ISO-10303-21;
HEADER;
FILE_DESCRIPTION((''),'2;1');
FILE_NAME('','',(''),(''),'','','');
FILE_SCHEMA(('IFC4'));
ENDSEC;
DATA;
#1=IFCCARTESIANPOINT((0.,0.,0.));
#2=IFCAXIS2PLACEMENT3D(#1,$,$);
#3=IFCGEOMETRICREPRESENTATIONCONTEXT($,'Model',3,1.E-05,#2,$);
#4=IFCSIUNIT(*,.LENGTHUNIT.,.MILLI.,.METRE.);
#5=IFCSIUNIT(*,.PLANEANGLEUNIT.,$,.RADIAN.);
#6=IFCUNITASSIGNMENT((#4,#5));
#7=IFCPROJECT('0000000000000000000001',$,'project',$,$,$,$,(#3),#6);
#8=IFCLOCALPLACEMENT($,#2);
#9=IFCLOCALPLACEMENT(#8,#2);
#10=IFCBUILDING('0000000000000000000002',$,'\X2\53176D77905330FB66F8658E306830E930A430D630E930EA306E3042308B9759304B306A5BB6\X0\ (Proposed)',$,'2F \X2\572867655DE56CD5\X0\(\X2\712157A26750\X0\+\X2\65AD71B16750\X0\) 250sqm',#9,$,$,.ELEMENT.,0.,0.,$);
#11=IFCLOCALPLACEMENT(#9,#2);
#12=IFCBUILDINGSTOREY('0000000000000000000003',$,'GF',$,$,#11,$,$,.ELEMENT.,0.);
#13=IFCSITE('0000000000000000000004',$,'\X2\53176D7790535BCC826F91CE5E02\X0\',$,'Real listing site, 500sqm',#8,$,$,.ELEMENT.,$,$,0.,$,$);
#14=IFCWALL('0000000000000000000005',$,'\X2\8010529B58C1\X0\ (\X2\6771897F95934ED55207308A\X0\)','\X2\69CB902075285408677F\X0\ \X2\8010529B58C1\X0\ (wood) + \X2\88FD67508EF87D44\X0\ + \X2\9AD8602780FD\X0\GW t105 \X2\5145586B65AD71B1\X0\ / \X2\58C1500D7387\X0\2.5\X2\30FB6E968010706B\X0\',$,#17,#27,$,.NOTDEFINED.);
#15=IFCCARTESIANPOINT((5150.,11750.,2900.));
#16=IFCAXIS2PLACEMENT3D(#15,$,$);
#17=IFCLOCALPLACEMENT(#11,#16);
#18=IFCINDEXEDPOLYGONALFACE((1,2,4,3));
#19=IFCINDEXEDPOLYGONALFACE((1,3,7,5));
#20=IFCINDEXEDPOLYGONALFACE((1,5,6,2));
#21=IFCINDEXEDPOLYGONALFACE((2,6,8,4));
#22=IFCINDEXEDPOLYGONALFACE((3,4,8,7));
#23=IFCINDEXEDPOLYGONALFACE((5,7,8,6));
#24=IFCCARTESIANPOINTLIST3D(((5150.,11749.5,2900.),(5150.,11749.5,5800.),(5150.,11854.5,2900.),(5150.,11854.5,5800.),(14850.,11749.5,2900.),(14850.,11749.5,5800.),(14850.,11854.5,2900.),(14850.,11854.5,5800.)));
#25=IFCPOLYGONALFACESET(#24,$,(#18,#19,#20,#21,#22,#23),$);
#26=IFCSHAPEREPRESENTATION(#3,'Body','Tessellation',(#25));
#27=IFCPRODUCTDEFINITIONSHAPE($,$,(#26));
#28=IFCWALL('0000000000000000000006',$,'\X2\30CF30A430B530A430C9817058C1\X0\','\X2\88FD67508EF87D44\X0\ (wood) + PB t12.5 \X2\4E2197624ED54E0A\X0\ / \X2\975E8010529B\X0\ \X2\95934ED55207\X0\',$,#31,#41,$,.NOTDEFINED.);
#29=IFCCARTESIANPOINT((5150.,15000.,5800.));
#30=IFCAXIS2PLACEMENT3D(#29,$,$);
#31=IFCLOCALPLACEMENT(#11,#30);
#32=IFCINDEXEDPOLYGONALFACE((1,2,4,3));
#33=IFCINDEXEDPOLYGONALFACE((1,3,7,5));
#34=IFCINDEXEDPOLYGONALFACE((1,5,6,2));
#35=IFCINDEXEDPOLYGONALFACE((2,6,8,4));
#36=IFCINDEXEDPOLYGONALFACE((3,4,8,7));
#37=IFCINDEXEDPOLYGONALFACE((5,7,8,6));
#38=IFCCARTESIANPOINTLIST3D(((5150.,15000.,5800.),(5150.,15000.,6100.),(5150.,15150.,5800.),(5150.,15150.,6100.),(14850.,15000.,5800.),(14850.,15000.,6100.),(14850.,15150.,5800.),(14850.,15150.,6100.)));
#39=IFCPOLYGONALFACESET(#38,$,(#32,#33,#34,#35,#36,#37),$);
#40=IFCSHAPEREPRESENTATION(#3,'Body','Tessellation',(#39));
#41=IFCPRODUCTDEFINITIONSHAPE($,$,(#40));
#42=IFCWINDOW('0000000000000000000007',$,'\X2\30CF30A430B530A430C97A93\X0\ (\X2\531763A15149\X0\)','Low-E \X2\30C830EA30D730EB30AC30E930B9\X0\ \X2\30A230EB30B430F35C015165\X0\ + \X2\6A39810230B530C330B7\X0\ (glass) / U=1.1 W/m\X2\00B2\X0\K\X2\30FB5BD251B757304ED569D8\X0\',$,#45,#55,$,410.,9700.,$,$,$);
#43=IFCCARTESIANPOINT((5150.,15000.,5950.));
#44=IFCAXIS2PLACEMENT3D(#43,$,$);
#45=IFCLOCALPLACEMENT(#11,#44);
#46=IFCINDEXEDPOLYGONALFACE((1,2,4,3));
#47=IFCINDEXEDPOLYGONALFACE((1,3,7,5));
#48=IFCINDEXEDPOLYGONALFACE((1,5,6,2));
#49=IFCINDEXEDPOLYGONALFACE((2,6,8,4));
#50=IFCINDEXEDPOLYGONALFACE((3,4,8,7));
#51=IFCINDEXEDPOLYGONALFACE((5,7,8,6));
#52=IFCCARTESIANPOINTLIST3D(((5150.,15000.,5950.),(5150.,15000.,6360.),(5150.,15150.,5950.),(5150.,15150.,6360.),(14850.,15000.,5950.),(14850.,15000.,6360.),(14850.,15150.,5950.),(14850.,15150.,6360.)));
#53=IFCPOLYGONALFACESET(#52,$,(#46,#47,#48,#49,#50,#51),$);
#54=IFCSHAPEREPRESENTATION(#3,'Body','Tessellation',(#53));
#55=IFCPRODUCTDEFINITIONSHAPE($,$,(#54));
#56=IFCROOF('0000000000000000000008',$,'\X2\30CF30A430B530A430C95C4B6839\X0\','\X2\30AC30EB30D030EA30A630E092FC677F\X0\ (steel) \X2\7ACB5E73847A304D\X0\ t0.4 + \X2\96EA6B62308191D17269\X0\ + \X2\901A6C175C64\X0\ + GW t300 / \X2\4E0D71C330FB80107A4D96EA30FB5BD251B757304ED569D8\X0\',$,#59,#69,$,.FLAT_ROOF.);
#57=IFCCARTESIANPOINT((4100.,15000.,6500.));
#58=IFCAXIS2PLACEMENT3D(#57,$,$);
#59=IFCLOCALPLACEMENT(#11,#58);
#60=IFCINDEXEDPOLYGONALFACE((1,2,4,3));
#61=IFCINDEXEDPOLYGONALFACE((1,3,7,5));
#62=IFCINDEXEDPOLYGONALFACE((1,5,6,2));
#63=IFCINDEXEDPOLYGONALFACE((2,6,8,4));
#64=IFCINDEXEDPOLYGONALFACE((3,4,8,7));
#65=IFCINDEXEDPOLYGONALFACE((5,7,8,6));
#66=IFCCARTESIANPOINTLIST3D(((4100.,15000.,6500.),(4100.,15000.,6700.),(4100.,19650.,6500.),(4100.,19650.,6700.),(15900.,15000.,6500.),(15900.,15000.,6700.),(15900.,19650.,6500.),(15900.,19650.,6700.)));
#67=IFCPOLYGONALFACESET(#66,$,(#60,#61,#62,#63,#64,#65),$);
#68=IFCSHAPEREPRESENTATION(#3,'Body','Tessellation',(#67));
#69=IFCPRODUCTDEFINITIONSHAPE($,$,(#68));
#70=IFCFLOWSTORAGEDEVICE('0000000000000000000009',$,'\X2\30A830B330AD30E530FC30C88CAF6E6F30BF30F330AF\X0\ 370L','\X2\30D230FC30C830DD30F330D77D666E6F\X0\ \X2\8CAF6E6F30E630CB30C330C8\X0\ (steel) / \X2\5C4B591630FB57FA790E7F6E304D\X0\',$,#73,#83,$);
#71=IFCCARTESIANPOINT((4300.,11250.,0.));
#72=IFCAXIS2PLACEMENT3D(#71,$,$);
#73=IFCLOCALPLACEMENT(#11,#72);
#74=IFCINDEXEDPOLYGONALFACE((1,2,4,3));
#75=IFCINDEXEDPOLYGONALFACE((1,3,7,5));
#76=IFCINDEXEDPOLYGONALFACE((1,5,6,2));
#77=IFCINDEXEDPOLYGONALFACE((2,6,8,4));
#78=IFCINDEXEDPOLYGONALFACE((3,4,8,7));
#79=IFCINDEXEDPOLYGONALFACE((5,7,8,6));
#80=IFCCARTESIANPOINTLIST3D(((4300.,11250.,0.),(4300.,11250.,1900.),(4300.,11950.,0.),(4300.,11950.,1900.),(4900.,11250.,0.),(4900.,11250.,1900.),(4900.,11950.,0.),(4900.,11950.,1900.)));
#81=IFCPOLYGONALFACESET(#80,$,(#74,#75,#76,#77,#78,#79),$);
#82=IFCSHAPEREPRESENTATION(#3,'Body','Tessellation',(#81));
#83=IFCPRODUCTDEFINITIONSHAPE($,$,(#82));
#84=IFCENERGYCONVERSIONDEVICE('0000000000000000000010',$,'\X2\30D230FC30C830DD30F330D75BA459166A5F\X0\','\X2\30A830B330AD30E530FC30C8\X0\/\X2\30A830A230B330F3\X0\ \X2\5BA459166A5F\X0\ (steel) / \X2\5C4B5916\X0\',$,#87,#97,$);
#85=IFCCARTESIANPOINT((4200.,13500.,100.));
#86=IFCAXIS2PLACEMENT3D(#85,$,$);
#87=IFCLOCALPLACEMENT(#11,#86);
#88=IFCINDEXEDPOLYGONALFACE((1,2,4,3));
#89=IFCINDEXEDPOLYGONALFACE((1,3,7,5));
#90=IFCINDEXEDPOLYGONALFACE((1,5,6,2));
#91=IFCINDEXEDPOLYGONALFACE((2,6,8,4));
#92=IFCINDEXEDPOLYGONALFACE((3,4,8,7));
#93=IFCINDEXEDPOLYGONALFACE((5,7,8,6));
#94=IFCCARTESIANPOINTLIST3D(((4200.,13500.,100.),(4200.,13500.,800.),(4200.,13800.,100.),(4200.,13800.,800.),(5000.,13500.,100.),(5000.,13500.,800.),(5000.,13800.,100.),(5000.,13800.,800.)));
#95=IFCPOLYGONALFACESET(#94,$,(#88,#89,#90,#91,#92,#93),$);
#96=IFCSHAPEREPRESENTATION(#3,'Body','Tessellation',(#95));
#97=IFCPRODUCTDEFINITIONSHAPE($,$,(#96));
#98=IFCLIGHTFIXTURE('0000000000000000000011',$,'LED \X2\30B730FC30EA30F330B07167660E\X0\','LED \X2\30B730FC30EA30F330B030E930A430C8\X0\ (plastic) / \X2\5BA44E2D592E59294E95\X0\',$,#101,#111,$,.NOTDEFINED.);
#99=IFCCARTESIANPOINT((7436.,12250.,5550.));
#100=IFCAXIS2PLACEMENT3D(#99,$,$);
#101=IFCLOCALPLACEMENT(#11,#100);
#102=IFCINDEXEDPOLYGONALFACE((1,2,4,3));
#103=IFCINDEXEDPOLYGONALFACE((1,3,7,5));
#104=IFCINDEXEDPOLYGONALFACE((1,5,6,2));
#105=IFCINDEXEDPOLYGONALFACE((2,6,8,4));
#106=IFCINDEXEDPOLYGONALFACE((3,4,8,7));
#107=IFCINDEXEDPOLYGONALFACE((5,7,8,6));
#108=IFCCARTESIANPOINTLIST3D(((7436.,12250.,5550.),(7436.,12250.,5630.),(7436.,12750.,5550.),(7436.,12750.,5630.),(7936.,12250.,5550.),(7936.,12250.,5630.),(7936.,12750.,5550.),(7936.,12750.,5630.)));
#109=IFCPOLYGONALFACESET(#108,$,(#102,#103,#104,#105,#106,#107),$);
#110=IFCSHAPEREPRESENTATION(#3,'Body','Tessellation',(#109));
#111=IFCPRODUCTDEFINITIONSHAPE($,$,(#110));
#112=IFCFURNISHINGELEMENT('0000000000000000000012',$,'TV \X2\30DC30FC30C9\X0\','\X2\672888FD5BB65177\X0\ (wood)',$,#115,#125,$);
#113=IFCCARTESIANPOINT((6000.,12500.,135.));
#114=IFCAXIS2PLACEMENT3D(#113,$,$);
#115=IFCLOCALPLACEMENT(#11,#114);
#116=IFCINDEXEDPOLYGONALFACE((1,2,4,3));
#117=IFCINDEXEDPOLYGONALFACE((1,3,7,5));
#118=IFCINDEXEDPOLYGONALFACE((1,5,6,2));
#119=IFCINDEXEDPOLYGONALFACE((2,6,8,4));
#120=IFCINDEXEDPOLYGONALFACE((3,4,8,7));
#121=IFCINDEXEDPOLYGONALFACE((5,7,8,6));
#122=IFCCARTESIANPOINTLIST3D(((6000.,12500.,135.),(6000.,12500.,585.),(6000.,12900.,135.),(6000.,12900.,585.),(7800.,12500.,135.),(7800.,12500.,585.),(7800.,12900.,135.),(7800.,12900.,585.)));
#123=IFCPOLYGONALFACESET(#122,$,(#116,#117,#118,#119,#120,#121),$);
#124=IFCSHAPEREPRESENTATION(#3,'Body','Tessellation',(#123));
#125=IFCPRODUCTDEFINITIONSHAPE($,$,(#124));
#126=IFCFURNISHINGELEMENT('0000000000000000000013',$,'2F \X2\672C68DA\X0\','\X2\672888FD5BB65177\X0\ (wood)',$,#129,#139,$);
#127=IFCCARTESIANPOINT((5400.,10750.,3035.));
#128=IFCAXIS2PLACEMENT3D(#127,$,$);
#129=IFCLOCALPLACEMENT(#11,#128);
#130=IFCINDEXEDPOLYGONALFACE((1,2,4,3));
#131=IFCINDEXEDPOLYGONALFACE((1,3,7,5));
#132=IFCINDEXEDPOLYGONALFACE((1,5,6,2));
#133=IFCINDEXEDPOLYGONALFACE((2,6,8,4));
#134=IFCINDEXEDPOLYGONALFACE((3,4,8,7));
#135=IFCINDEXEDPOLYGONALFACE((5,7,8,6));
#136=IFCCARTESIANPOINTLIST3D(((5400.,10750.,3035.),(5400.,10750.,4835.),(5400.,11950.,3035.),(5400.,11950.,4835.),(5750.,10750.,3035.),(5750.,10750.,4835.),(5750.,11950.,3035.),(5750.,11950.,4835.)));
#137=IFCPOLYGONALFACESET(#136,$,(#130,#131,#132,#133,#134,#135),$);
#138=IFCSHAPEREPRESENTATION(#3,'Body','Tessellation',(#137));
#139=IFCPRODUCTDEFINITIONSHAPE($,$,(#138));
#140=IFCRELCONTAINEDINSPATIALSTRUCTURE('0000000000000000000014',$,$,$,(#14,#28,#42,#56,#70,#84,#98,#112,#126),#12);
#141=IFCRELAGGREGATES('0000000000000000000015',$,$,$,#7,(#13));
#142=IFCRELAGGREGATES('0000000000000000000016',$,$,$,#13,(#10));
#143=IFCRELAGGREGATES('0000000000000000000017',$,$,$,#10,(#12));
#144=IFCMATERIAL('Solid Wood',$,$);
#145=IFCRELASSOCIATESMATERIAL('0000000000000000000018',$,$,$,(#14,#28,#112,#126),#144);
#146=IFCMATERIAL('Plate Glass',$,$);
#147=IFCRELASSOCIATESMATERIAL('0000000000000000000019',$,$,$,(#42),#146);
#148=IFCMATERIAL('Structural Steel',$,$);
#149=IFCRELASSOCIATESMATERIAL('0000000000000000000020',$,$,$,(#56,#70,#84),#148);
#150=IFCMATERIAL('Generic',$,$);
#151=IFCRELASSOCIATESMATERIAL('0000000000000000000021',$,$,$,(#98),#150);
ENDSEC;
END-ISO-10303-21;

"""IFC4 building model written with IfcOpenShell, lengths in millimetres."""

from ifc_helpers import new_model, si_unit, frame, frame_2d, origin, place, context, project, spatial, rectangle, extrude, material, element, fill, save


model = new_model("IFC4")

# Units and contexts
model_context = context("Model", 3, precision=1e-05, world=origin())
ifc_project = project(units=[si_unit("LENGTHUNIT", "METRE", prefix="MILLI"), si_unit("PLANEANGLEUNIT", "RADIAN")], contexts=[model_context])

# Site, building, storey
site_placement = place(None, origin())
site = spatial("IfcSite", under=ifc_project, at=site_placement, Name="北海道富良野市", ObjectType="Real listing site, 500sqm", CompositionType="ELEMENT", RefElevation=0.0)
building_placement = place(site_placement, origin())
building = spatial("IfcBuilding", under=site, at=building_placement, Name="北海道・書斎とライブラリのある静かな家 (Proposed)", ObjectType="2F 在来工法(無垢材+断熱材) 250sqm", CompositionType="ELEMENT", ElevationOfRefHeight=0.0, ElevationOfTerrain=0.0)
storey_placement = place(building_placement, origin())
storey = spatial("IfcBuildingStorey", under=building, at=storey_placement, Name="GF", CompositionType="ELEMENT", Elevation=0.0)

# Shared definitions
ifc_material_1 = material(Name="Solid Wood")

# Wall
wall_1_placement = place(storey_placement, frame((5150.0, 11750.0, 2900.0)))
element("IfcWall", 1, at=wall_1_placement, inside=storey, material=ifc_material_1, Name="耐力壁 (東西間仕切り)", Description="構造用合板 耐力壁 (wood) + 製材軸組 + 高性能GW t105 充填断熱 / 壁倍率2.5・準耐火", PredefinedType="NOTDEFINED", context=model_context, shape_type="SweptSolid", body=[
    extrude(rectangle(XDim=9700.0, YDim=105.0, at=frame_2d((4850.0, 52.0))), frame((5150.0, 11750.0, 2900.0)), (0.0, 0.0, 1.0), 2900.0),
])

# Wall, opening, window
wall_2_placement = place(storey_placement, frame((5150.0, 15000.0, 5800.0)))
wall_2 = element("IfcWall", 2, at=wall_2_placement, inside=storey, material=ifc_material_1, Name="ハイサイド腰壁", Description="製材軸組 (wood) + PB t12.5 両面仕上 / 非耐力 間仕切", PredefinedType="NOTDEFINED", context=model_context, shape_type="SweptSolid", body=[
    extrude(rectangle(XDim=9700.0, YDim=150.0, at=frame_2d((4850.0, 75.0))), frame((5150.0, 15000.0, 5800.0)), (0.0, 0.0, 1.0), 700.0),
])
opening_1_placement = place(storey_placement, frame((5150.0, 15000.0, 5950.0)))
opening_1 = element("IfcOpeningElement", 3, at=opening_1_placement, cuts=wall_2, PredefinedType="NOTDEFINED", context=model_context, shape_type="SweptSolid", body=[
    extrude(rectangle(XDim=9700.0, YDim=150.0, at=frame_2d((4850.0, 75.0))), frame((5150.0, 15000.0, 5950.0)), (0.0, 0.0, 1.0), 410.0),
])
ifc_material_2 = material(Name="Plate Glass")
window_placement = place(storey_placement, frame((5150.0, 15000.0, 5950.0)))
window = element("IfcWindow", 4, at=window_placement, inside=storey, material=ifc_material_2, Name="ハイサイド窓 (北採光)", Description="Low-E トリプルガラス アルゴン封入 + 樹脂サッシ (glass) / U=1.1 W/m²K・寒冷地仕様", OverallHeight=410.0, OverallWidth=9700.0, context=model_context, shape_type="SweptSolid", body=[
    extrude(rectangle(XDim=9700.0, YDim=150.0, at=frame_2d((4850.0, 75.0))), frame((5150.0, 15000.0, 5950.0)), (0.0, 0.0, 1.0), 410.0),
])
fill(opening_1, window)

# Roof
ifc_material_3 = material(Name="Structural Steel")
roof_placement = place(storey_placement, frame((4100.0, 15000.0, 6500.0)))
element("IfcRoof", 5, at=roof_placement, inside=storey, material=ifc_material_3, Name="ハイサイド屋根", Description="ガルバリウム鋼板 (steel) 立平葺き t0.4 + 雪止め金物 + 通気層 + GW t300 / 不燃・耐積雪・寒冷地仕様", PredefinedType="FLAT_ROOF", context=model_context, shape_type="SweptSolid", body=[
    extrude(rectangle(XDim=11800.0, YDim=4650.0, at=frame_2d((5900.0, 2325.0))), frame((4100.0, 15000.0, 6500.0)), (0.0, 0.0, 1.0), 200.0),
])

# Flow storage device
flow_storage_device_placement = place(storey_placement, frame((4300.0, 11250.0, 0.0)))
element("IfcFlowStorageDevice", 6, at=flow_storage_device_placement, inside=storey, material=ifc_material_3, Name="エコキュート貯湯タンク 370L", Description="ヒートポンプ給湯 貯湯ユニット (steel) / 屋外・基礎置き", context=model_context, shape_type="SweptSolid", body=[
    extrude(rectangle(XDim=600.0, YDim=700.0, at=frame_2d((300.0, 350.0))), frame((4300.0, 11250.0, 0.0)), (0.0, 0.0, 1.0), 1900.0),
])

# Energy conversion device
energy_conversion_device_placement = place(storey_placement, frame((4200.0, 13500.0, 100.0)))
element("IfcEnergyConversionDevice", 7, at=energy_conversion_device_placement, inside=storey, material=ifc_material_3, Name="ヒートポンプ室外機", Description="エコキュート/エアコン 室外機 (steel) / 屋外", context=model_context, shape_type="SweptSolid", body=[
    extrude(rectangle(XDim=800.0, YDim=300.0, at=frame_2d((400.0, 150.0))), frame((4200.0, 13500.0, 100.0)), (0.0, 0.0, 1.0), 700.0),
])

# Light fixture
ifc_material_4 = material(Name="Generic")
light_fixture_placement = place(storey_placement, frame((7436.0, 12250.0, 5550.0)))
element("IfcLightFixture", 8, at=light_fixture_placement, inside=storey, material=ifc_material_4, Name="LED シーリング照明", Description="LED シーリングライト (plastic) / 室中央天井", PredefinedType="NOTDEFINED", context=model_context, shape_type="SweptSolid", body=[
    extrude(rectangle(XDim=500.0, YDim=500.0, at=frame_2d((250.0, 250.0))), frame((7436.0, 12250.0, 5550.0)), (0.0, 0.0, 1.0), 80.0),
])

# Furnishing elements
furnishing_1_placement = place(storey_placement, frame((6000.0, 12500.0, 135.0)))
element("IfcFurnishingElement", 9, at=furnishing_1_placement, inside=storey, material=ifc_material_1, Name="TV ボード", Description="木製家具 (wood)", context=model_context, shape_type="SweptSolid", body=[
    extrude(rectangle(XDim=1800.0, YDim=400.0, at=frame_2d((900.0, 200.0))), frame((6000.0, 12500.0, 135.0)), (0.0, 0.0, 1.0), 450.0),
])
furnishing_2_placement = place(storey_placement, frame((5400.0, 10750.0, 3035.0)))
element("IfcFurnishingElement", 10, at=furnishing_2_placement, inside=storey, material=ifc_material_1, Name="2F 本棚", Description="木製家具 (wood)", context=model_context, shape_type="SweptSolid", body=[
    extrude(rectangle(XDim=350.0, YDim=1200.0, at=frame_2d((175.0, 600.0))), frame((5400.0, 10750.0, 3035.0)), (0.0, 0.0, 1.0), 1800.0),
])

save(model, "model.ifc")
